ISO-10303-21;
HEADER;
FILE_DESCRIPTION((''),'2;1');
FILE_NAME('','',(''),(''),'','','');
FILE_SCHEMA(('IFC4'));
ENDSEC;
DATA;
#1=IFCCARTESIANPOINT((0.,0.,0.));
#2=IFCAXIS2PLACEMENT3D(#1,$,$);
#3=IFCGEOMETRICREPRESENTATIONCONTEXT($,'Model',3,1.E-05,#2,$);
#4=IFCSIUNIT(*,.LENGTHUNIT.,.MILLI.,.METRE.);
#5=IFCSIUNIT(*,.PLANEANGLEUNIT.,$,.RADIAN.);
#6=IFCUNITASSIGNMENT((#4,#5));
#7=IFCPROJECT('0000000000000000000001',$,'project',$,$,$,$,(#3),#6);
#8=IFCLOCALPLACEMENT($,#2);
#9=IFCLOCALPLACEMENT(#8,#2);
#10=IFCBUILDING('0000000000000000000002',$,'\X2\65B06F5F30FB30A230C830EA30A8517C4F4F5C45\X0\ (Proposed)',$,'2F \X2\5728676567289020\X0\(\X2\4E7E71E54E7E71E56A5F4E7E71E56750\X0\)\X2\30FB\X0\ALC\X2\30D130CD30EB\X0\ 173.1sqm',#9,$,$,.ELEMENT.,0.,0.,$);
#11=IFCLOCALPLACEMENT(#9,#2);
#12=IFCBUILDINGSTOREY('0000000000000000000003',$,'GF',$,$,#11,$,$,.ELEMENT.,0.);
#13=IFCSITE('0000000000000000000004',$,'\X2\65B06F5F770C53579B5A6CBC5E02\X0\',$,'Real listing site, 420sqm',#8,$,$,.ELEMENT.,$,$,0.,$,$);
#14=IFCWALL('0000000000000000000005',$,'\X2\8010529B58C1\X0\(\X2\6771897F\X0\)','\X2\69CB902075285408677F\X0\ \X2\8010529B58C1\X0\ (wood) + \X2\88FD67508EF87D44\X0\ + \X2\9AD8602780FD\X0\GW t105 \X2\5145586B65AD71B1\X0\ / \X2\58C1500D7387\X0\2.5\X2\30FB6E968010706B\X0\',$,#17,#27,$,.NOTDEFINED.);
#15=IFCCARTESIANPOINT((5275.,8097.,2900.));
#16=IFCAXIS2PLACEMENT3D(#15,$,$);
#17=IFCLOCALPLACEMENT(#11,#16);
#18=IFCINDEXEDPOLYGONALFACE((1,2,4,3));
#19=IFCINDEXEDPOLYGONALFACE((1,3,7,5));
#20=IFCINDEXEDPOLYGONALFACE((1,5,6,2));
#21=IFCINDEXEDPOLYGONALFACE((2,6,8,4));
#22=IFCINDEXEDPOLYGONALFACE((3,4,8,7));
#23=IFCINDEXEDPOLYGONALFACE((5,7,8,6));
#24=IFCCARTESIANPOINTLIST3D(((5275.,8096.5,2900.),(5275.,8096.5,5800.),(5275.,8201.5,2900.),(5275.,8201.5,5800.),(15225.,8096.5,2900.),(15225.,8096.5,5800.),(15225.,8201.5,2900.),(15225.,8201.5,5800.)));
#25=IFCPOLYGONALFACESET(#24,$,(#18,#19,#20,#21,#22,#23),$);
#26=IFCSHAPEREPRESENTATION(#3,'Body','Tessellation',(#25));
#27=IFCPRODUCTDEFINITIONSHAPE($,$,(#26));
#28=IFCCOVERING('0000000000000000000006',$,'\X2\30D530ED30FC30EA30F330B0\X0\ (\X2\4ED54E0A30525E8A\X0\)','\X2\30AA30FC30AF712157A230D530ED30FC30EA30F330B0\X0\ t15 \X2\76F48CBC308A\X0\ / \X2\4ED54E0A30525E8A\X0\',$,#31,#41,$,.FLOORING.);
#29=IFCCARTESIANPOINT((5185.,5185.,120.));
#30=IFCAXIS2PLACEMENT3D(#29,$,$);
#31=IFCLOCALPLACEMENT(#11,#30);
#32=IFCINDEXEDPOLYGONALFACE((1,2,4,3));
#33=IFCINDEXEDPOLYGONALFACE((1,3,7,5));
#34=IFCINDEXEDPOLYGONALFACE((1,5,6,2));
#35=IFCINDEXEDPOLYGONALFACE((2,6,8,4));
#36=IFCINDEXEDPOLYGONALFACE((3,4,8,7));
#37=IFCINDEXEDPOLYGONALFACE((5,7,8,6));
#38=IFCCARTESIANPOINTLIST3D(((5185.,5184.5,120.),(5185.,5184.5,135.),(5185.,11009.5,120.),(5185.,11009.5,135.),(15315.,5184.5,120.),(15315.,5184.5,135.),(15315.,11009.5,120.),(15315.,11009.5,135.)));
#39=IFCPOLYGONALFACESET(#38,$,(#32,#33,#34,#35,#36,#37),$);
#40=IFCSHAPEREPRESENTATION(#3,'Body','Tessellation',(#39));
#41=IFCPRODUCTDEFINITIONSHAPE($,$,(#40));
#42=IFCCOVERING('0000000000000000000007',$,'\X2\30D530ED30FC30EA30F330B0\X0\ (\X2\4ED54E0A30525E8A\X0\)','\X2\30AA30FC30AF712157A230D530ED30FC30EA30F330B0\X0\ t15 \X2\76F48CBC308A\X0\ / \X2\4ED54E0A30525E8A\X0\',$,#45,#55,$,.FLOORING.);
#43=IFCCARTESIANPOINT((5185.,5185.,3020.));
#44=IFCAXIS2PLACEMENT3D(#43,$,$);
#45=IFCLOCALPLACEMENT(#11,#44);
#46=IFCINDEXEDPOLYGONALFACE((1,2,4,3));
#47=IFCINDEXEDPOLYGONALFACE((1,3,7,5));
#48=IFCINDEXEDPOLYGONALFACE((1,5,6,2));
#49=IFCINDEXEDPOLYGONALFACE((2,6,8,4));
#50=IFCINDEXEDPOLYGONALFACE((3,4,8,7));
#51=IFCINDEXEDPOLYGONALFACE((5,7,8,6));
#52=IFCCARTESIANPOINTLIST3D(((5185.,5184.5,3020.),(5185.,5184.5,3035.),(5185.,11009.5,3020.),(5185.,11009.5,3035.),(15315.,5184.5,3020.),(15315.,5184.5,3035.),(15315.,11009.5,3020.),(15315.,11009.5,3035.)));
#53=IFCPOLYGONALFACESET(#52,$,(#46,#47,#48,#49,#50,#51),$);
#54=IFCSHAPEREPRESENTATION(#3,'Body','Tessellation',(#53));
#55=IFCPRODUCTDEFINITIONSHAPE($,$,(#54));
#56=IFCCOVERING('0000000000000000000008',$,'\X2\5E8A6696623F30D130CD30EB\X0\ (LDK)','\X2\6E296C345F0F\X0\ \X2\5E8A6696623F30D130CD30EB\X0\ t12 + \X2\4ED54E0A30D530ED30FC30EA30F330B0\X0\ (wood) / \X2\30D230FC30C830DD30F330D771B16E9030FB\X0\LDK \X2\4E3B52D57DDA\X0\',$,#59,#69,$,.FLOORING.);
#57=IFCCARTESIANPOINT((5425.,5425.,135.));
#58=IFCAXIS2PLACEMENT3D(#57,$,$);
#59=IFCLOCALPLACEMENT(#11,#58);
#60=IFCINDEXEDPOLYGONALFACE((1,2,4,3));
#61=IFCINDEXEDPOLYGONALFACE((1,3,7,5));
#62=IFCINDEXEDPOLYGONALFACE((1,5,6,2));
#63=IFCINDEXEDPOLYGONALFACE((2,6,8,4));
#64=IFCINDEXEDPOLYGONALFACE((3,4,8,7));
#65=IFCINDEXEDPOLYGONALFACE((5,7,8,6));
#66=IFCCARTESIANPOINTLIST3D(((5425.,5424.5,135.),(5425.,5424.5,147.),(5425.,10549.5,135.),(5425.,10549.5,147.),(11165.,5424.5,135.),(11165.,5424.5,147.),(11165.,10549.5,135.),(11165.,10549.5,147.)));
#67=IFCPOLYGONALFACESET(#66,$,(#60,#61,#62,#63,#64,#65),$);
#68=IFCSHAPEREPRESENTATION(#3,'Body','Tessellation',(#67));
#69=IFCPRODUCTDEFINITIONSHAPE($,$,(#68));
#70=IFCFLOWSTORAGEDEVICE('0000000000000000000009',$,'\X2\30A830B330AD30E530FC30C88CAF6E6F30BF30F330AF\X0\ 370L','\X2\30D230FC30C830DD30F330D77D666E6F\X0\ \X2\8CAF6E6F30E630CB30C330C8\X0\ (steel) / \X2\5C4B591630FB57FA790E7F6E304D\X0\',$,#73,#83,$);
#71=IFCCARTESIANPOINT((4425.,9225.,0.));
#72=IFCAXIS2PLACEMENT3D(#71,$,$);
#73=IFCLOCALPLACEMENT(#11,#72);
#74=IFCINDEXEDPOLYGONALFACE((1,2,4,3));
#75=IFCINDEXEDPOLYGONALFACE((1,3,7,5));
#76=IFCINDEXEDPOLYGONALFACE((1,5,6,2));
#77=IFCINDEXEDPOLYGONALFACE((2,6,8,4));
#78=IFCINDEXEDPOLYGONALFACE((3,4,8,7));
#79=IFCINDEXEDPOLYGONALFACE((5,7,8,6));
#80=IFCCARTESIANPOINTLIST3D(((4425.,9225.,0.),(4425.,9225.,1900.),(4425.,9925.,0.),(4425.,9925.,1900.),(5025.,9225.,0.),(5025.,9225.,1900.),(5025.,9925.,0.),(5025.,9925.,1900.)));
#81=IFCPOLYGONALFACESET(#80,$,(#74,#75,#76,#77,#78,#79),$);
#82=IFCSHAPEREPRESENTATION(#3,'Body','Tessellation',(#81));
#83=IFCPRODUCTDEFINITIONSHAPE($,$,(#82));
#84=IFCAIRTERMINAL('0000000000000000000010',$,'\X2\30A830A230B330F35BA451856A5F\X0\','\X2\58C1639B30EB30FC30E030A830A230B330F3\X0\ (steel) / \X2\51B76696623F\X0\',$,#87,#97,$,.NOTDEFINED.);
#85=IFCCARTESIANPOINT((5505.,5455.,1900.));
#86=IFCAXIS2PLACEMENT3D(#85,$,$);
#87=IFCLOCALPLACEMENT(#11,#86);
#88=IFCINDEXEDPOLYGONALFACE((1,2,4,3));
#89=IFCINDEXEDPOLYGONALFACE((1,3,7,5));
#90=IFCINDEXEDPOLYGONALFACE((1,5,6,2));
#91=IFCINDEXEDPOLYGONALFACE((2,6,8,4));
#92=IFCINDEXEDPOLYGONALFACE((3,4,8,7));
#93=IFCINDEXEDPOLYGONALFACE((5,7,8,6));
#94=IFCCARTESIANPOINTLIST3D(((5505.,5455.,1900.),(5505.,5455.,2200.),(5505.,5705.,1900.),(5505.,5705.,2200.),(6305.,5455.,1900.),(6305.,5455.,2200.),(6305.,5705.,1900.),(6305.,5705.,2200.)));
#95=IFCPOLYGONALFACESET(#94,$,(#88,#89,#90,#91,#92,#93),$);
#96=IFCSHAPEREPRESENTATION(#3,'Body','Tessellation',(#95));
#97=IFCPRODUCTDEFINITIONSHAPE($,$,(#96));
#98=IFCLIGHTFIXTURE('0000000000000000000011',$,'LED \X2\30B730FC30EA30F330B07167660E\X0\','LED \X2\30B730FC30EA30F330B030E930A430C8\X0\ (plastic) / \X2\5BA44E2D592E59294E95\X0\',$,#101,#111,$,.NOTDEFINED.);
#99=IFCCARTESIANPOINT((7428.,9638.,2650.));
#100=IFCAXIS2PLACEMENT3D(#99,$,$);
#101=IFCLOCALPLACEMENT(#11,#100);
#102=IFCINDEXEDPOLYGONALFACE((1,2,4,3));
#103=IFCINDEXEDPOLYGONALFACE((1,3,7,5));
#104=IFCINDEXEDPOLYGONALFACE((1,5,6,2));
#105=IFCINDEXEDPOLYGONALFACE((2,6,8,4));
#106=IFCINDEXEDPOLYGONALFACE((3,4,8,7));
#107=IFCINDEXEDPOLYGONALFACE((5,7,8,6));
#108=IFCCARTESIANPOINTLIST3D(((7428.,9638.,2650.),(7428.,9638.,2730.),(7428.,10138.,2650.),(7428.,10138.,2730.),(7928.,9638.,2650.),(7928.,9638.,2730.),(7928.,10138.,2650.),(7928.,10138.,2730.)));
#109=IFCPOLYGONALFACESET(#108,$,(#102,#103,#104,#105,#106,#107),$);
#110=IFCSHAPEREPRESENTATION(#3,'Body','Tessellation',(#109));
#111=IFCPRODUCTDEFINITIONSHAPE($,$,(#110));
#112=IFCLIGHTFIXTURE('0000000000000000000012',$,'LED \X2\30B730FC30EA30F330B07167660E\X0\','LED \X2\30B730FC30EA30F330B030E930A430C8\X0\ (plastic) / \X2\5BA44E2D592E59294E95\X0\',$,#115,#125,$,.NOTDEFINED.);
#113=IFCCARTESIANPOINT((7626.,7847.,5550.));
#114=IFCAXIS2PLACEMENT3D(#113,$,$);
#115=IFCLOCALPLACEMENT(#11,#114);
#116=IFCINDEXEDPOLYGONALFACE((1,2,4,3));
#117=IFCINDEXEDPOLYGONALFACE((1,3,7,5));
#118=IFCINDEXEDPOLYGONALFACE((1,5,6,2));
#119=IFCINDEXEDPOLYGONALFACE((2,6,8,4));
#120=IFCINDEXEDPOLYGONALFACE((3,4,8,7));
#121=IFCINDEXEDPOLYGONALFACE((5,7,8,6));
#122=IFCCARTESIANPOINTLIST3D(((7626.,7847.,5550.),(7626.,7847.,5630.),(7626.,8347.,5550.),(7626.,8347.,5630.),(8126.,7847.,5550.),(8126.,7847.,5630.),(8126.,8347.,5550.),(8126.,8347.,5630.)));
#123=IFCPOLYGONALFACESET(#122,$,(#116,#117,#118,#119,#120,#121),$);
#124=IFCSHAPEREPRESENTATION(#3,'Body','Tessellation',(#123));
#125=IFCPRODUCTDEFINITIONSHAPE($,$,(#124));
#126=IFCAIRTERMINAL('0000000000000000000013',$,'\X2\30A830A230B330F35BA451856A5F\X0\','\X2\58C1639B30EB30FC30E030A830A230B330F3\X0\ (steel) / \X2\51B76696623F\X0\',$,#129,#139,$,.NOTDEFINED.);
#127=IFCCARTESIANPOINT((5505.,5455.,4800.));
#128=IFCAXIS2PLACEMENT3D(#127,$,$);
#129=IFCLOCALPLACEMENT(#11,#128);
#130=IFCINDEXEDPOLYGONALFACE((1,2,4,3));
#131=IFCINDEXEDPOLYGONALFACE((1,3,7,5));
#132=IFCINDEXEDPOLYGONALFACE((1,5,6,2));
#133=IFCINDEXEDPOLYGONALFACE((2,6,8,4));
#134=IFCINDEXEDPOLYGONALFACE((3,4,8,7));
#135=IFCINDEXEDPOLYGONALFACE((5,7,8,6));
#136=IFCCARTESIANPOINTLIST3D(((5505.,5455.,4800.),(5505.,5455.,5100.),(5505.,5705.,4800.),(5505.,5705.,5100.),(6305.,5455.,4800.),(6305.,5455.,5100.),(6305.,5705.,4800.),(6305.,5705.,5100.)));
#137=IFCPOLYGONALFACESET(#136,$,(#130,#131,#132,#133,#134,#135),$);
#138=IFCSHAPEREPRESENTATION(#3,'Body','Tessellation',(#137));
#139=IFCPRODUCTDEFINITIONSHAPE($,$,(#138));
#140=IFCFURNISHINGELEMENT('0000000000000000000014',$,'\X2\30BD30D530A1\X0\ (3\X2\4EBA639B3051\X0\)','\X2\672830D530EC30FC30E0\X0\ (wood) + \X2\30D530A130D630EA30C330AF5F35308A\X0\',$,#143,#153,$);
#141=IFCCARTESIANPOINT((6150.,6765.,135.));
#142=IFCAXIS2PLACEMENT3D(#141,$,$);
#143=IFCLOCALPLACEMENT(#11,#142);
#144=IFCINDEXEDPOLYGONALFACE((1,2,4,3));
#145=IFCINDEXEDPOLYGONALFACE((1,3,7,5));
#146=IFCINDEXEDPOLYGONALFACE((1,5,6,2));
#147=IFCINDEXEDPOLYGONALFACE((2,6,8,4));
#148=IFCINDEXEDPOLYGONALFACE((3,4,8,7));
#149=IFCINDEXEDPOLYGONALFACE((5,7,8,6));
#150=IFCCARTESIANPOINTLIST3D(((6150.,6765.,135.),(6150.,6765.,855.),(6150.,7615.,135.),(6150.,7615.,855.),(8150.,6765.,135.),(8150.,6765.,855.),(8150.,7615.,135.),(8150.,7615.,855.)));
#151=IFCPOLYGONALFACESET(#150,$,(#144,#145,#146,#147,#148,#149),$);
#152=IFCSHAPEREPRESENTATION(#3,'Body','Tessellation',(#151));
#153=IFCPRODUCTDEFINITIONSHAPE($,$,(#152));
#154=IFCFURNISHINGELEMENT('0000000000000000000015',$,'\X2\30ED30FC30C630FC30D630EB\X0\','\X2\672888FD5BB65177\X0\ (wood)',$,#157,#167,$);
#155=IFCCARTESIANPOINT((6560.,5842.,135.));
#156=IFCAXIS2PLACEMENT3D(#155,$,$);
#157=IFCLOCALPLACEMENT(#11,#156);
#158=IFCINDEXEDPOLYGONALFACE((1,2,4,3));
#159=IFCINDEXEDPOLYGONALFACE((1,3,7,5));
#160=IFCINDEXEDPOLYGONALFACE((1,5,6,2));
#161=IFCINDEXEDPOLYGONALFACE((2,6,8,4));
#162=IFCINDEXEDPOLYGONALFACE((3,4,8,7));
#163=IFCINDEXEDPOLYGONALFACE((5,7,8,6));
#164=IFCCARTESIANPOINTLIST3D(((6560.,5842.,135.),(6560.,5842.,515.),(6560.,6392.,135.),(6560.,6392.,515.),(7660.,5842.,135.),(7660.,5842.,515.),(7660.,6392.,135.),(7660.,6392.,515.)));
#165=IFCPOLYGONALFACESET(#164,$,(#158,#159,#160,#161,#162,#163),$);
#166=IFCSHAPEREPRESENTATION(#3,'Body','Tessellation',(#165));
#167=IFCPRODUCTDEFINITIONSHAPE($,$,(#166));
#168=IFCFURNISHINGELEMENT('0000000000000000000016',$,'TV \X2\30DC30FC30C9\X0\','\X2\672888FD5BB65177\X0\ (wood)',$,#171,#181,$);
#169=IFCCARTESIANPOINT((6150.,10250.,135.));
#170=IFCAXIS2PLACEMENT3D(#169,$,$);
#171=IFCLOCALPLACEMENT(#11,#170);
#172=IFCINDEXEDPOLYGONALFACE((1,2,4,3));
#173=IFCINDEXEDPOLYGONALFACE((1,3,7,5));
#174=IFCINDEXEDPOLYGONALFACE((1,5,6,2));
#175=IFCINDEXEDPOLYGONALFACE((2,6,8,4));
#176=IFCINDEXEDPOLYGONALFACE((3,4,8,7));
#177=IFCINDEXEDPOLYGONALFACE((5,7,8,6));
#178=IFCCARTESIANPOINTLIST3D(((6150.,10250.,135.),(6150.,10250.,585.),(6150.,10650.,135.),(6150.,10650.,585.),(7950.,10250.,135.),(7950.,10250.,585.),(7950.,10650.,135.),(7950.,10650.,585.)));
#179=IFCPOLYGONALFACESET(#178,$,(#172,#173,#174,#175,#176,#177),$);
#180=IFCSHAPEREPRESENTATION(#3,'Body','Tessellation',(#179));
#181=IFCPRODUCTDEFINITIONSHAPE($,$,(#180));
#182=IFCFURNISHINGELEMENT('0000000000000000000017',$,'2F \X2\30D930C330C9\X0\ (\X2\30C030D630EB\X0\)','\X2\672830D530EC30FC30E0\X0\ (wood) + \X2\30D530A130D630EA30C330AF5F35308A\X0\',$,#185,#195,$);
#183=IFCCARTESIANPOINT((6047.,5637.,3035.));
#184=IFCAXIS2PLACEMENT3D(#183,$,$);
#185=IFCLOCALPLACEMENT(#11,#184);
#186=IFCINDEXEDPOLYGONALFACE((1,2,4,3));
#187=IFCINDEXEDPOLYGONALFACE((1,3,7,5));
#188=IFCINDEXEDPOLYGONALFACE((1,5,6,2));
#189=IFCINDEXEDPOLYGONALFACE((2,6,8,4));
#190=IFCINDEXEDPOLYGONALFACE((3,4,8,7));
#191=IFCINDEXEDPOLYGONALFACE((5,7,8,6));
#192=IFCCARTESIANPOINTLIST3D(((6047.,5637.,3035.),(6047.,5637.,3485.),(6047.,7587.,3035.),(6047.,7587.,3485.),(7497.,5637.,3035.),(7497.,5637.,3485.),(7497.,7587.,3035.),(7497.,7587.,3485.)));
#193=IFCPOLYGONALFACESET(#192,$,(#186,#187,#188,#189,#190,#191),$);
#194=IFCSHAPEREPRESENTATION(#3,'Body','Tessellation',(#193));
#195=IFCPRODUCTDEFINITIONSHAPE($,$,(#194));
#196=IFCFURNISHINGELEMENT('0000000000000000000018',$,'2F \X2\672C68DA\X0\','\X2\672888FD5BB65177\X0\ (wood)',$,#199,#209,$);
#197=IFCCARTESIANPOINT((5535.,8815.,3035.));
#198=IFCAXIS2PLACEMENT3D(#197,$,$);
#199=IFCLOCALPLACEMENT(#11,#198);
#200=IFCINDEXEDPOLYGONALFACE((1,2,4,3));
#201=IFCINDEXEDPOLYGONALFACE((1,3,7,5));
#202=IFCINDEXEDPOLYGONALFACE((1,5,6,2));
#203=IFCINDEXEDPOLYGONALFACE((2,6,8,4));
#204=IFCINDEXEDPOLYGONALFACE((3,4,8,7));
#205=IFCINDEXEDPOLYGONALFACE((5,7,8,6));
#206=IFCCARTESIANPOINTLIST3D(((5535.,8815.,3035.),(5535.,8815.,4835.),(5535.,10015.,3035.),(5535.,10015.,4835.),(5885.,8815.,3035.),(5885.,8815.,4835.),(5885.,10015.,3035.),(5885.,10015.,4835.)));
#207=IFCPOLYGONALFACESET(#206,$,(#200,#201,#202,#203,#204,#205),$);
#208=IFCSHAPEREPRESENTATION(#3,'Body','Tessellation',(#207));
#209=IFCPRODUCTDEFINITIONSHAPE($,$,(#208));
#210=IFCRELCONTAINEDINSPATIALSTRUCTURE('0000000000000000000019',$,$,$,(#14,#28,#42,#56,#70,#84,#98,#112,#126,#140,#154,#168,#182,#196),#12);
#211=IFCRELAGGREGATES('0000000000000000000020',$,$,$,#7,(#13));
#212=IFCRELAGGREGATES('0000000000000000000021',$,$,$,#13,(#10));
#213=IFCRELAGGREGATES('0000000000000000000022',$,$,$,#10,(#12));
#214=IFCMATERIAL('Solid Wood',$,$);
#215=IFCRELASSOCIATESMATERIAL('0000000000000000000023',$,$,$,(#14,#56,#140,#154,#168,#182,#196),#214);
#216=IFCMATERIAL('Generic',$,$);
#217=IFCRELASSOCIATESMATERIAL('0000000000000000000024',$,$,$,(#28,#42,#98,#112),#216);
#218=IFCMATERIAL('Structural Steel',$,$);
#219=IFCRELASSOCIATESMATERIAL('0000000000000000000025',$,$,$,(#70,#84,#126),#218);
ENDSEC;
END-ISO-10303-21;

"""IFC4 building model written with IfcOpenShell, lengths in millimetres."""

from ifc_helpers import new_model, si_unit, frame, frame_2d, origin, place, context, project, spatial, rectangle, extrude, material, element, save


model = new_model("IFC4")

# Units and contexts
model_context = context("Model", 3, precision=1e-05, world=origin())
ifc_project = project(units=[si_unit("LENGTHUNIT", "METRE", prefix="MILLI"), si_unit("PLANEANGLEUNIT", "RADIAN")], contexts=[model_context])

# Site, building, storey
site_placement = place(None, origin())
site = spatial("IfcSite", under=ifc_project, at=site_placement, Name="新潟県南魚沼市", ObjectType="Real listing site, 420sqm", CompositionType="ELEMENT", RefElevation=0.0)
building_placement = place(site_placement, origin())
building = spatial("IfcBuilding", under=site, at=building_placement, Name="新潟・アトリエ兼住居 (Proposed)", ObjectType="2F 在来木造(乾燥乾燥機乾燥材)・ALCパネル 173.1sqm", CompositionType="ELEMENT", ElevationOfRefHeight=0.0, ElevationOfTerrain=0.0)
storey_placement = place(building_placement, origin())
storey = spatial("IfcBuildingStorey", under=building, at=storey_placement, Name="GF", CompositionType="ELEMENT", Elevation=0.0)

# Shared definitions
ifc_material_1 = material(Name="Solid Wood")

# Wall
wall_1_placement = place(storey_placement, frame((5275.0, 8097.0, 2900.0)))
element("IfcWall", 1, at=wall_1_placement, inside=storey, material=ifc_material_1, Name="耐力壁(東西)", Description="構造用合板 耐力壁 (wood) + 製材軸組 + 高性能GW t105 充填断熱 / 壁倍率2.5・準耐火", PredefinedType="NOTDEFINED", context=model_context, shape_type="SweptSolid", body=[
    extrude(rectangle(XDim=9950.0, YDim=105.0, at=frame_2d((4975.0, 52.0))), frame((5275.0, 8097.0, 2900.0)), (0.0, 0.0, 1.0), 2900.0),
])

# Coverings
ifc_material_2 = material(Name="Generic")
covering_1_placement = place(storey_placement, frame((5185.0, 5185.0, 120.0)))
element("IfcCovering", 2, at=covering_1_placement, inside=storey, material=ifc_material_2, Name="フローリング (仕上げ床)", Description="オーク無垢フローリング t15 直貼り / 仕上げ床", PredefinedType="FLOORING", context=model_context, shape_type="SweptSolid", body=[
    extrude(rectangle(XDim=10130.0, YDim=5825.0, at=frame_2d((5065.0, 2912.0))), frame((5185.0, 5185.0, 120.0)), (0.0, 0.0, 1.0), 15.0),
])
covering_2_placement = place(storey_placement, frame((5185.0, 5185.0, 3020.0)))
element("IfcCovering", 3, at=covering_2_placement, inside=storey, material=ifc_material_2, Name="フローリング (仕上げ床)", Description="オーク無垢フローリング t15 直貼り / 仕上げ床", PredefinedType="FLOORING", context=model_context, shape_type="SweptSolid", body=[
    extrude(rectangle(XDim=10130.0, YDim=5825.0, at=frame_2d((5065.0, 2912.0))), frame((5185.0, 5185.0, 3020.0)), (0.0, 0.0, 1.0), 15.0),
])
covering_3_placement = place(storey_placement, frame((5425.0, 5425.0, 135.0)))
element("IfcCovering", 4, at=covering_3_placement, inside=storey, material=ifc_material_1, Name="床暖房パネル (LDK)", Description="温水式 床暖房パネル t12 + 仕上フローリング (wood) / ヒートポンプ熱源・LDK 主動線", PredefinedType="FLOORING", context=model_context, shape_type="SweptSolid", body=[
    extrude(rectangle(XDim=5740.0, YDim=5125.0, at=frame_2d((2870.0, 2562.0))), frame((5425.0, 5425.0, 135.0)), (0.0, 0.0, 1.0), 12.0),
])

# Flow storage device
ifc_material_3 = material(Name="Structural Steel")
flow_storage_device_placement = place(storey_placement, frame((4425.0, 9225.0, 0.0)))
element("IfcFlowStorageDevice", 5, at=flow_storage_device_placement, inside=storey, material=ifc_material_3, Name="エコキュート貯湯タンク 370L", Description="ヒートポンプ給湯 貯湯ユニット (steel) / 屋外・基礎置き", context=model_context, shape_type="SweptSolid", body=[
    extrude(rectangle(XDim=600.0, YDim=700.0, at=frame_2d((300.0, 350.0))), frame((4425.0, 9225.0, 0.0)), (0.0, 0.0, 1.0), 1900.0),
])

# Air terminal
air_terminal_1_placement = place(storey_placement, frame((5505.0, 5455.0, 1900.0)))
element("IfcAirTerminal", 6, at=air_terminal_1_placement, inside=storey, material=ifc_material_3, Name="エアコン室内機", Description="壁掛ルームエアコン (steel) / 冷暖房", PredefinedType="NOTDEFINED", context=model_context, shape_type="SweptSolid", body=[
    extrude(rectangle(XDim=800.0, YDim=250.0, at=frame_2d((400.0, 125.0))), frame((5505.0, 5455.0, 1900.0)), (0.0, 0.0, 1.0), 300.0),
])

# Light fixtures
light_fixture_1_placement = place(storey_placement, frame((7428.0, 9638.0, 2650.0)))
element("IfcLightFixture", 7, at=light_fixture_1_placement, inside=storey, material=ifc_material_2, Name="LED シーリング照明", Description="LED シーリングライト (plastic) / 室中央天井", PredefinedType="NOTDEFINED", context=model_context, shape_type="SweptSolid", body=[
    extrude(rectangle(XDim=500.0, YDim=500.0, at=frame_2d((250.0, 250.0))), frame((7428.0, 9638.0, 2650.0)), (0.0, 0.0, 1.0), 80.0),
])
light_fixture_2_placement = place(storey_placement, frame((7626.0, 7847.0, 5550.0)))
element("IfcLightFixture", 8, at=light_fixture_2_placement, inside=storey, material=ifc_material_2, Name="LED シーリング照明", Description="LED シーリングライト (plastic) / 室中央天井", PredefinedType="NOTDEFINED", context=model_context, shape_type="SweptSolid", body=[
    extrude(rectangle(XDim=500.0, YDim=500.0, at=frame_2d((250.0, 250.0))), frame((7626.0, 7847.0, 5550.0)), (0.0, 0.0, 1.0), 80.0),
])

# Air terminal
air_terminal_2_placement = place(storey_placement, frame((5505.0, 5455.0, 4800.0)))
element("IfcAirTerminal", 9, at=air_terminal_2_placement, inside=storey, material=ifc_material_3, Name="エアコン室内機", Description="壁掛ルームエアコン (steel) / 冷暖房", PredefinedType="NOTDEFINED", context=model_context, shape_type="SweptSolid", body=[
    extrude(rectangle(XDim=800.0, YDim=250.0, at=frame_2d((400.0, 125.0))), frame((5505.0, 5455.0, 4800.0)), (0.0, 0.0, 1.0), 300.0),
])

# Furnishing elements
furnishing_1_placement = place(storey_placement, frame((6150.0, 6765.0, 135.0)))
element("IfcFurnishingElement", 10, at=furnishing_1_placement, inside=storey, material=ifc_material_1, Name="ソファ (3人掛け)", Description="木フレーム (wood) + ファブリック張り", context=model_context, shape_type="SweptSolid", body=[
    extrude(rectangle(XDim=2000.0, YDim=850.0, at=frame_2d((1000.0, 425.0))), frame((6150.0, 6765.0, 135.0)), (0.0, 0.0, 1.0), 720.0),
])
furnishing_2_placement = place(storey_placement, frame((6560.0, 5842.0, 135.0)))
element("IfcFurnishingElement", 11, at=furnishing_2_placement, inside=storey, material=ifc_material_1, Name="ローテーブル", Description="木製家具 (wood)", context=model_context, shape_type="SweptSolid", body=[
    extrude(rectangle(XDim=1100.0, YDim=550.0, at=frame_2d((550.0, 275.0))), frame((6560.0, 5842.0, 135.0)), (0.0, 0.0, 1.0), 380.0),
])
furnishing_3_placement = place(storey_placement, frame((6150.0, 10250.0, 135.0)))
element("IfcFurnishingElement", 12, at=furnishing_3_placement, inside=storey, material=ifc_material_1, Name="TV ボード", Description="木製家具 (wood)", context=model_context, shape_type="SweptSolid", body=[
    extrude(rectangle(XDim=1800.0, YDim=400.0, at=frame_2d((900.0, 200.0))), frame((6150.0, 10250.0, 135.0)), (0.0, 0.0, 1.0), 450.0),
])
furnishing_4_placement = place(storey_placement, frame((6047.0, 5637.0, 3035.0)))
element("IfcFurnishingElement", 13, at=furnishing_4_placement, inside=storey, material=ifc_material_1, Name="2F ベッド (ダブル)", Description="木フレーム (wood) + ファブリック張り", context=model_context, shape_type="SweptSolid", body=[
    extrude(rectangle(XDim=1450.0, YDim=1950.0, at=frame_2d((725.0, 975.0))), frame((6047.0, 5637.0, 3035.0)), (0.0, 0.0, 1.0), 450.0),
])
furnishing_5_placement = place(storey_placement, frame((5535.0, 8815.0, 3035.0)))
element("IfcFurnishingElement", 14, at=furnishing_5_placement, inside=storey, material=ifc_material_1, Name="2F 本棚", Description="木製家具 (wood)", context=model_context, shape_type="SweptSolid", body=[
    extrude(rectangle(XDim=350.0, YDim=1200.0, at=frame_2d((175.0, 600.0))), frame((5535.0, 8815.0, 3035.0)), (0.0, 0.0, 1.0), 1800.0),
])

save(model, "model.ifc")
